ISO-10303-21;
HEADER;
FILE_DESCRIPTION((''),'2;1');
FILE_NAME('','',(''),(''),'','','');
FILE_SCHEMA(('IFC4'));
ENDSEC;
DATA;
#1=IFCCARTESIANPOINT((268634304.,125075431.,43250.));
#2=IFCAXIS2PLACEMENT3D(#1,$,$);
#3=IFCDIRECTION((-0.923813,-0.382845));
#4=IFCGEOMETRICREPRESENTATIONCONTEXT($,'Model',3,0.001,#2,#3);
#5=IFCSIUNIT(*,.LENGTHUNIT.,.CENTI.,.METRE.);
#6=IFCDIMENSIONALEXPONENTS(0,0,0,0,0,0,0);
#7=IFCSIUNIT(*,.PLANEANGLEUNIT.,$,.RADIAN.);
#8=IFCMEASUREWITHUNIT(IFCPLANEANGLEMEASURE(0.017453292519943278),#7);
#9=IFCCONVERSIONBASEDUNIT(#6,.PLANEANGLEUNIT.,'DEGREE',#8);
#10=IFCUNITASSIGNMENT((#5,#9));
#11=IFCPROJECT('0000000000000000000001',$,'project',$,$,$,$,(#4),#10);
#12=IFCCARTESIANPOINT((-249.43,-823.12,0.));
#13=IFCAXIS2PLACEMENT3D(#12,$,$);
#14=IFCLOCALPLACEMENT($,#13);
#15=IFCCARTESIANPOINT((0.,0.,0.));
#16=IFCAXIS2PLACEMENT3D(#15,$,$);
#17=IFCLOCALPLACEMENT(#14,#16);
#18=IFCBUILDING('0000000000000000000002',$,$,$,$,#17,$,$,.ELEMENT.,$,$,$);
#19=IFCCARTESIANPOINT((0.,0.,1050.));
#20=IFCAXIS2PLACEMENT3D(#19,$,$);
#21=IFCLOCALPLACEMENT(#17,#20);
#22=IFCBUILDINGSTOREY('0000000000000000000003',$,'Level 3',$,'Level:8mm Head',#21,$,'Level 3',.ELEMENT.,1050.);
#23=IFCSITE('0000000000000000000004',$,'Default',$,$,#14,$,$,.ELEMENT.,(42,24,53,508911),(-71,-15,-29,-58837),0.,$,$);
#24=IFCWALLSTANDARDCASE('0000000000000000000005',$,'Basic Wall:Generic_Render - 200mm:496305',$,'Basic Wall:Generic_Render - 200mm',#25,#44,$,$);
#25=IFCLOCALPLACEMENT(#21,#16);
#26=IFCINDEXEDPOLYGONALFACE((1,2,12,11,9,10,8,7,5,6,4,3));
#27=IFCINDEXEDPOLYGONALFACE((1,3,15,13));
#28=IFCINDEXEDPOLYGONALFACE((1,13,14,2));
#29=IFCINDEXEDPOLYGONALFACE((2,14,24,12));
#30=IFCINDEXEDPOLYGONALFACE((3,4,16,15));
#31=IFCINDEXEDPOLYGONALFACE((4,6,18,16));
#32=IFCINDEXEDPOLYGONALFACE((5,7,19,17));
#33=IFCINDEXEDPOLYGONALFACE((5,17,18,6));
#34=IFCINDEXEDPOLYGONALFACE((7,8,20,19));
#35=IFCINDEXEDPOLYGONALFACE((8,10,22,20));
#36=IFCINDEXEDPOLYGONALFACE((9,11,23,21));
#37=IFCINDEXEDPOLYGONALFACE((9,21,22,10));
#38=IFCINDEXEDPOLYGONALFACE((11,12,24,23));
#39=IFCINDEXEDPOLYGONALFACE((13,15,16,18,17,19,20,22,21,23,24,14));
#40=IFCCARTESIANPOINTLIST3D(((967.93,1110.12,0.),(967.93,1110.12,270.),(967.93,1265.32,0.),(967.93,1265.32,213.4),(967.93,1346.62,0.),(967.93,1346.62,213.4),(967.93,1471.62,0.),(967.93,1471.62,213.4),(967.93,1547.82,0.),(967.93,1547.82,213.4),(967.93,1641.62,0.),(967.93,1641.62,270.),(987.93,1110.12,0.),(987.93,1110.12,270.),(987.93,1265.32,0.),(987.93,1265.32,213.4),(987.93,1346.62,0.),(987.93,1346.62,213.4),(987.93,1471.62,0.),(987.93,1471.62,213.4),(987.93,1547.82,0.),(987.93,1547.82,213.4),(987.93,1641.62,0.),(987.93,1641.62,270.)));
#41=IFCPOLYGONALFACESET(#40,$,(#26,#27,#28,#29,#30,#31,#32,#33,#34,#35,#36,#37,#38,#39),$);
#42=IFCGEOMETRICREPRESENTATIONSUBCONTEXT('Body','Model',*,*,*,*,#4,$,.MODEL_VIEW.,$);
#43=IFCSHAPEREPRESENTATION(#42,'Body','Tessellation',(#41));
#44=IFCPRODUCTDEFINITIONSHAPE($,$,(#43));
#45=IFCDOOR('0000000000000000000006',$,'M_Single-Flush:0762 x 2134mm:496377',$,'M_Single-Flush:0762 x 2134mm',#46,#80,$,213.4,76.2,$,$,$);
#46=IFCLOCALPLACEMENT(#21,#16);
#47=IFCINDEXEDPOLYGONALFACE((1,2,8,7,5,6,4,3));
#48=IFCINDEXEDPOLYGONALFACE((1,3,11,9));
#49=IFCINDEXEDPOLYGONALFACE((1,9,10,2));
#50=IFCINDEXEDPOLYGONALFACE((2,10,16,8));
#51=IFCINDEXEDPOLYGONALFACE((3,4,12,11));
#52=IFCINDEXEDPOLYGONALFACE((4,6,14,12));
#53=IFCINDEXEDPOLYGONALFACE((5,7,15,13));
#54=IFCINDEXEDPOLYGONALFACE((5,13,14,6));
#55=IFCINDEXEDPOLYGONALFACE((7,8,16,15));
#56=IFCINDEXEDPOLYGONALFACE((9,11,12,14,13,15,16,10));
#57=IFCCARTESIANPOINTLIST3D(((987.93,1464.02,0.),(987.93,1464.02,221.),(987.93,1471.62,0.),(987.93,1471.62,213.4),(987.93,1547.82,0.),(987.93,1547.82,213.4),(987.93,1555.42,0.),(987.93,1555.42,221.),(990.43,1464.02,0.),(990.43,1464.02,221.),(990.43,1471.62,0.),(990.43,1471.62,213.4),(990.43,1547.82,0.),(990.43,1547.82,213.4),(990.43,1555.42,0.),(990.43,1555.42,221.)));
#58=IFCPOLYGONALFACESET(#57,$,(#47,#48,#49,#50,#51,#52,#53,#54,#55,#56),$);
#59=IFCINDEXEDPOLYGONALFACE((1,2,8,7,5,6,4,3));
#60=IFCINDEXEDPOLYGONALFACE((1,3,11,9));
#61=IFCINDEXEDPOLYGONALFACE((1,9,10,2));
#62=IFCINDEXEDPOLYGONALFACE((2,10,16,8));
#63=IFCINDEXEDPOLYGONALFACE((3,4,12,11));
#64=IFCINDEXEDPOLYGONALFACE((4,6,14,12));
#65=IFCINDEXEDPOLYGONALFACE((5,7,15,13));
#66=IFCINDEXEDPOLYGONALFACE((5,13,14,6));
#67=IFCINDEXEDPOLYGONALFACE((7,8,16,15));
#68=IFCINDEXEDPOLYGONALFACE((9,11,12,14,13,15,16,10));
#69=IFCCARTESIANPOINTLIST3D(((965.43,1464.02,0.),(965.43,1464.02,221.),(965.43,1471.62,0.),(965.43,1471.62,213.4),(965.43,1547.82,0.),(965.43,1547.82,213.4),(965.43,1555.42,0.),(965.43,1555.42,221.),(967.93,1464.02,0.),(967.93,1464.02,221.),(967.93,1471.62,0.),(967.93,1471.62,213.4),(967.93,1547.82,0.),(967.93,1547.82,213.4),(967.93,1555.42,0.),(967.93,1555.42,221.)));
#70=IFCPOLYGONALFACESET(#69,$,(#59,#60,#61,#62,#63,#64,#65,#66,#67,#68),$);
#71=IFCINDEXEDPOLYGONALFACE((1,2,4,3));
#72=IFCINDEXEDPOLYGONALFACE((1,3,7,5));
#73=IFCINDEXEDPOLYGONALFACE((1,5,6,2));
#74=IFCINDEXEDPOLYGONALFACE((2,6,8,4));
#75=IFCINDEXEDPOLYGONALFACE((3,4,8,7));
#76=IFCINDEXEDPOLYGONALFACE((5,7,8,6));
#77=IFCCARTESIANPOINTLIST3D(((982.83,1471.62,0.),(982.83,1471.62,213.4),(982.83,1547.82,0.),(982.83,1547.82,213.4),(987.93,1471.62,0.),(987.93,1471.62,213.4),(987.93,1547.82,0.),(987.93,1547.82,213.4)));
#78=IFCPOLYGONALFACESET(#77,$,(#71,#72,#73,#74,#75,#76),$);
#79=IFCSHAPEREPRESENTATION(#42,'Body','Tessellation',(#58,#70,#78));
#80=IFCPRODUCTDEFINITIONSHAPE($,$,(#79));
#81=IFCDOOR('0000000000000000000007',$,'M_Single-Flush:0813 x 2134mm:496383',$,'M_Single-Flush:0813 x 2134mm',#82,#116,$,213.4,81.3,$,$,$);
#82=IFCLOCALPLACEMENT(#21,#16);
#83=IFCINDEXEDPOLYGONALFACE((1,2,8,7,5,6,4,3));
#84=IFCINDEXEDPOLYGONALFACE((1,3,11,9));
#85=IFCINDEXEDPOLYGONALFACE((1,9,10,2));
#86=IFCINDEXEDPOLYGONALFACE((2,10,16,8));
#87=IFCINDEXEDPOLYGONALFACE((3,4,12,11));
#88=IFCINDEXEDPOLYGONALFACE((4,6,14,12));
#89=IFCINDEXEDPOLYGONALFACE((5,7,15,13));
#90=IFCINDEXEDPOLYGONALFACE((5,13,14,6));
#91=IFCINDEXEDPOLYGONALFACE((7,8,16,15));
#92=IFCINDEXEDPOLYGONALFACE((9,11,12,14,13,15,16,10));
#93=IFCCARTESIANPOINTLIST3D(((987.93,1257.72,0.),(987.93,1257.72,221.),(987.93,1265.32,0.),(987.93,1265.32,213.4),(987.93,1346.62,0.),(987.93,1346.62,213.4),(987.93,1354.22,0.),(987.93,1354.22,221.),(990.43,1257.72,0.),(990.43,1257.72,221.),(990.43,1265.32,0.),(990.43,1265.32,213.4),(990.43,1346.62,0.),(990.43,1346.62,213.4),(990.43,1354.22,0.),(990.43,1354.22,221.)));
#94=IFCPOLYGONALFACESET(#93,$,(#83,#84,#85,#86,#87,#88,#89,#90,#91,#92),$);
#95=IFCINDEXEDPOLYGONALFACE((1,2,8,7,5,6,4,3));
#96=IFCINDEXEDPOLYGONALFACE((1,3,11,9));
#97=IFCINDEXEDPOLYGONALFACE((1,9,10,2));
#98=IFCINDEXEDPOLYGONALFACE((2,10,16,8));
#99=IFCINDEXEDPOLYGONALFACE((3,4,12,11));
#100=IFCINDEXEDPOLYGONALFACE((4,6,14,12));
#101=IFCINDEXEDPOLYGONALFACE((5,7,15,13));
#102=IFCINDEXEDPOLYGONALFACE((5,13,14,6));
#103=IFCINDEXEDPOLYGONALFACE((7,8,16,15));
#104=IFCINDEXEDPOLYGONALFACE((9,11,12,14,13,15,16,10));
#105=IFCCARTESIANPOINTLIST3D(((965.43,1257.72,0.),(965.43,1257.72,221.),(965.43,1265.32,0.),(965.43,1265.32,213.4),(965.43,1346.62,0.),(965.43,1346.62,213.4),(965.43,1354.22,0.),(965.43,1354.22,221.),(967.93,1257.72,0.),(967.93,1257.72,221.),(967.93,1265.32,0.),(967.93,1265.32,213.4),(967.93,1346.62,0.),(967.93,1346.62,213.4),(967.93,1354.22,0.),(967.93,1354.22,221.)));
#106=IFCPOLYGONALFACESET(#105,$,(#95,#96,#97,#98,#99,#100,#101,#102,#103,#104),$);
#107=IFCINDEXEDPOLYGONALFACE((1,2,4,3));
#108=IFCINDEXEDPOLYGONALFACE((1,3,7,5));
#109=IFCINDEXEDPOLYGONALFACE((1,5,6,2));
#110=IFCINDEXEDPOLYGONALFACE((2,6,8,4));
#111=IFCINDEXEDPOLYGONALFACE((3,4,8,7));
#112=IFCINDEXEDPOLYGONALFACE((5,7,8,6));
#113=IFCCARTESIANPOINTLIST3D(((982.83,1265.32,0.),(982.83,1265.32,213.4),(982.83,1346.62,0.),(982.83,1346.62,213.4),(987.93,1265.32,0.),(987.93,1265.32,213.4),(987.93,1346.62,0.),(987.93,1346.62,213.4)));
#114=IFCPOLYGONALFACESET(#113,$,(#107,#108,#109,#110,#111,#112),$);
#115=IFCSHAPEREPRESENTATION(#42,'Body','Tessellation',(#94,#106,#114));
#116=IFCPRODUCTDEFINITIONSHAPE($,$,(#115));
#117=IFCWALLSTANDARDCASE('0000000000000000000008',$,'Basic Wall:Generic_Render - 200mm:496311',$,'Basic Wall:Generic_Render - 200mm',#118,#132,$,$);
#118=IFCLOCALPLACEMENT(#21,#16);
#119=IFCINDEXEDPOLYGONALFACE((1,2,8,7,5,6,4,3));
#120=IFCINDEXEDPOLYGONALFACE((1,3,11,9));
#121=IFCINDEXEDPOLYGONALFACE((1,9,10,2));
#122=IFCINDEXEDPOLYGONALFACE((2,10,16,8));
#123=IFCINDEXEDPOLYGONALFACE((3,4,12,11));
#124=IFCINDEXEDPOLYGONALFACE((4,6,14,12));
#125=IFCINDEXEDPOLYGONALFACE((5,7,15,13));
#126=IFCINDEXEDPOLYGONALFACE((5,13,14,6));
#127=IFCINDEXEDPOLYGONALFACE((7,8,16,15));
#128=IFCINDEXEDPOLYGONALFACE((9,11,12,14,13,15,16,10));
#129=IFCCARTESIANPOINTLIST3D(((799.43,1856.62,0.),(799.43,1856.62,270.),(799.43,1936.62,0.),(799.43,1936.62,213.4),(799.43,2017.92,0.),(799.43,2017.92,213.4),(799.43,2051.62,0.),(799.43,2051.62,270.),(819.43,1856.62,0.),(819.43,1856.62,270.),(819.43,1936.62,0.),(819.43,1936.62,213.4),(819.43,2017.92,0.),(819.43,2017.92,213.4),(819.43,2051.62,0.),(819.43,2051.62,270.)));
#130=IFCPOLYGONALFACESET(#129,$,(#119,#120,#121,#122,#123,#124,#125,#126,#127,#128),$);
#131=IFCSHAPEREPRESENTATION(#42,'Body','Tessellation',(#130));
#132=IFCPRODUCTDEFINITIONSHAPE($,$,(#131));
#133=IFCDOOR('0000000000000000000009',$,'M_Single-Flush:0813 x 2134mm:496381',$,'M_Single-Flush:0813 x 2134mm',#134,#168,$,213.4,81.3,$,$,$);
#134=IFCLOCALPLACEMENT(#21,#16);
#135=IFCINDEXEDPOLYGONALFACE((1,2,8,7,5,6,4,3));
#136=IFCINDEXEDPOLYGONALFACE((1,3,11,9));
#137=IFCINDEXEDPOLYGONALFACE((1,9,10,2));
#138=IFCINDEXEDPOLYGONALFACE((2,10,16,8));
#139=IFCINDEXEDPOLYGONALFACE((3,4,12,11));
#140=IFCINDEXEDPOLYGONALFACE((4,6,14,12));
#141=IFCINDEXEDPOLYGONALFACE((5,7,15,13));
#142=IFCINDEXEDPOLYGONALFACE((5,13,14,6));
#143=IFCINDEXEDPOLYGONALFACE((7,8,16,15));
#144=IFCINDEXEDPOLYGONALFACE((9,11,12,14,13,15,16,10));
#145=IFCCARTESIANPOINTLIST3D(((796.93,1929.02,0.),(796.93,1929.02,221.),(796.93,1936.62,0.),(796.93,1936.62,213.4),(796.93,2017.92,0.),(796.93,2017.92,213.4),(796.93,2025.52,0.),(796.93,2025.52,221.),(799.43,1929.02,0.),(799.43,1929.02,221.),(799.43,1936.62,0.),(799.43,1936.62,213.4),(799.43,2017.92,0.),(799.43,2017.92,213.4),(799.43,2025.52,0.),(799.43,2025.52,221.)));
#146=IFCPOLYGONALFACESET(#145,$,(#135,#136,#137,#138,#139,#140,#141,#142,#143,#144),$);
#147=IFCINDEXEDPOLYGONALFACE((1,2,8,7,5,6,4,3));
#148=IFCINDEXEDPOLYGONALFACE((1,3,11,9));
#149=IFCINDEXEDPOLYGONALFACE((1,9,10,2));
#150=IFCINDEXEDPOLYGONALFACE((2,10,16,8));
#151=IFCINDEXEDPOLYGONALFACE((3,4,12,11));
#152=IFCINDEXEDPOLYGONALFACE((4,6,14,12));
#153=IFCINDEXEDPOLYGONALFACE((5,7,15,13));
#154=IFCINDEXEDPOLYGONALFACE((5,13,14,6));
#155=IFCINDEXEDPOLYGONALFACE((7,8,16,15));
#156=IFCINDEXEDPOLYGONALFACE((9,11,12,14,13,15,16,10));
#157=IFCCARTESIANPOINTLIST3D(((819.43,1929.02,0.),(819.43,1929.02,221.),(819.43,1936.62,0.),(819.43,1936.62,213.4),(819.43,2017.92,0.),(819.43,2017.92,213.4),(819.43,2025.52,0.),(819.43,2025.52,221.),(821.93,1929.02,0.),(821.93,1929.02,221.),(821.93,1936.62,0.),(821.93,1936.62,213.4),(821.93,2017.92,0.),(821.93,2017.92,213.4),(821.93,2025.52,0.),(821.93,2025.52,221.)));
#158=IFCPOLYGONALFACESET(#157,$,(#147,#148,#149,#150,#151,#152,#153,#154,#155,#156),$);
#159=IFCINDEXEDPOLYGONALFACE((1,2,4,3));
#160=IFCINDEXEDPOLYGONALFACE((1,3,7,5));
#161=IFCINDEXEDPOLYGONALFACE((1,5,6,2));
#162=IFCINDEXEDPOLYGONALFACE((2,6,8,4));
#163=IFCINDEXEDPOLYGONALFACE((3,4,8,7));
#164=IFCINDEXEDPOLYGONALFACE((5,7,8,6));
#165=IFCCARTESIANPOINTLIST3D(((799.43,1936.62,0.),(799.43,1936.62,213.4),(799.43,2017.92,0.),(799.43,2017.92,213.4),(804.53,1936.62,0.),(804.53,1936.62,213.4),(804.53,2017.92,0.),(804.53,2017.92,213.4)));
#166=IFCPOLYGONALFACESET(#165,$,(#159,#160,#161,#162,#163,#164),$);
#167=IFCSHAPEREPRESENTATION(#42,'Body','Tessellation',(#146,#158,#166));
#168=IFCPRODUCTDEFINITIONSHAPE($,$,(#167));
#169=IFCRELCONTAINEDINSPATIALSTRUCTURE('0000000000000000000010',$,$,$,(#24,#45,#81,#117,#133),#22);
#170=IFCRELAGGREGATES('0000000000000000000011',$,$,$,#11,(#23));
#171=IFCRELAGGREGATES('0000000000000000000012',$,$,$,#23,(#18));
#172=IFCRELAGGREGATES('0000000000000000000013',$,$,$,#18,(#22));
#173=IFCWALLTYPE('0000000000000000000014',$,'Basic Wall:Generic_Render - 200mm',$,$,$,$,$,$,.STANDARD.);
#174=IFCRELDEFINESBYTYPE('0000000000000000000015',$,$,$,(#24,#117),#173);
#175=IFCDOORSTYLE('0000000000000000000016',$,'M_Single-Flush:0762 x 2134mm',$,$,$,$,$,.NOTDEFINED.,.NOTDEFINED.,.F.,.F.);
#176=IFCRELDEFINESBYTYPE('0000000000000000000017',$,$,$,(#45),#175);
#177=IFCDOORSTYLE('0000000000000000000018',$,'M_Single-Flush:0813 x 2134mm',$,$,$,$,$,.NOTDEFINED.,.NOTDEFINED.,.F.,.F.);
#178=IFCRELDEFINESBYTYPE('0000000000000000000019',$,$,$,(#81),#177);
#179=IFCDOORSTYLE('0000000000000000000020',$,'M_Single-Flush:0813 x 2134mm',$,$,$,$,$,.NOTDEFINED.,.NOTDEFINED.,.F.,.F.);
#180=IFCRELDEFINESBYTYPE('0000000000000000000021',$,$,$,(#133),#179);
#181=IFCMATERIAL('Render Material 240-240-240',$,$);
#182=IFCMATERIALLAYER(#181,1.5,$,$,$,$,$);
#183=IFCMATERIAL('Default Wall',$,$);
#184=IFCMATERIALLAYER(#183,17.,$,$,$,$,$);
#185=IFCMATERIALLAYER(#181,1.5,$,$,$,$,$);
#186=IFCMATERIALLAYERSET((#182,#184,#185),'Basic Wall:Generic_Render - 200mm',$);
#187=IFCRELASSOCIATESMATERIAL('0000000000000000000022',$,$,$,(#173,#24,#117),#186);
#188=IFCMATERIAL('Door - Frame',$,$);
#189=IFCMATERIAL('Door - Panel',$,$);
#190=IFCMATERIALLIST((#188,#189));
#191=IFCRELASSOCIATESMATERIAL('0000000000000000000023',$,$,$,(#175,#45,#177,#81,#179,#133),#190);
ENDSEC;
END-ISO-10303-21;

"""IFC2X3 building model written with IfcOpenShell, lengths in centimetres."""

from ifc_helpers import new_model, entity, si_unit, converted_unit, direction, frame, frame_2d, origin, place, context, subcontext, project, spatial, polyline, rectangle, outline, extrude, source, transform, mapped, material, material_list, layer, layer_set, layer_usage, type_object, type_shapes, element, fill, save


model = new_model("IFC2X3")

# Units and contexts
model_context = context("Model", 3, precision=0.001, world=frame((268634304.0, 125075431.0, 43250.0)), true_north=direction((-0.923813, -0.382845)))
body_context = subcontext(model_context, "Body", "Model", "MODEL_VIEW")
ifc_project = project(units=[si_unit("LENGTHUNIT", "METRE", prefix="CENTI"), converted_unit("PLANEANGLEUNIT", "DEGREE", entity("IfcPlaneAngleMeasure", 0.017453292519943278), si_unit("PLANEANGLEUNIT", "RADIAN"), dimensions=[0, 0, 0, 0, 0, 0, 0])], contexts=[model_context])

# Site, building, storey
site_placement = place(None, frame((-249.43, -823.12, 0.0)))
site = spatial("IfcSite", under=ifc_project, at=site_placement, Name="Default", CompositionType="ELEMENT", RefLatitude=(42, 24, 53, 508911), RefLongitude=(-71, -15, -29, -58837), RefElevation=0.0)
building_placement = place(site_placement, origin())
building = spatial("IfcBuilding", under=site, at=building_placement, CompositionType="ELEMENT")
storey_placement = place(building_placement, frame((0.0, 0.0, 1050.0)))
storey = spatial("IfcBuildingStorey", under=building, at=storey_placement, Name="Level 3", ObjectType="Level:8mm Head", LongName="Level 3", CompositionType="ELEMENT", Elevation=1050.0)

# Shared definitions
ifc_material_1 = material(Name="Render Material 240-240-240")

# Shared definitions
ifc_layer_1 = layer(ifc_material_1, 1.5)
ifc_material_2 = material(Name="Default Wall")
ifc_layer_2 = layer(ifc_material_2, 17.0)
ifc_layer_3 = layer(ifc_material_1, 1.5)
ifc_layer_set_1 = layer_set([ifc_layer_1, ifc_layer_2, ifc_layer_3], Name="Basic Wall:Generic_Render - 200mm")
wall_type_1 = type_object("IfcWallType", Name="Basic Wall:Generic_Render - 200mm", PredefinedType="STANDARD", material=ifc_layer_set_1)
ifc_material_3 = material(Name="Door - Frame")
ifc_material_4 = material(Name="Door - Panel")
ifc_material_list = material_list([ifc_material_3, ifc_material_4])

# Wall, openings, doors
ifc_layer_usage_1 = layer_usage(ifc_layer_set_1, "AXIS2", "NEGATIVE", 10.0)
wall_1_placement = place(storey_placement, frame((977.93, 1641.62, 0.0), z_axis=(0.0, 0.0, 1.0), x_axis=(0.0, -1.0, 0.0)))
wall_1 = element("IfcWallStandardCase", 1, at=wall_1_placement, inside=storey, type_object=wall_type_1, material=ifc_layer_usage_1, Name="Basic Wall:Generic_Render - 200mm:496305", ObjectType="Basic Wall:Generic_Render - 200mm", context=body_context, shape_type="SweptSolid", body=[
    extrude(rectangle(XDim=531.5, YDim=20.0, at=frame_2d((265.75, 0.0), x_axis=(1.0, 0.0))), origin(), (0.0, 0.0, 1.0), 270.0),
])
opening_1_placement = place(wall_1_placement, frame((93.8, -10.0, 0.0)))
opening_1 = element("IfcOpeningElement", 2, at=opening_1_placement, cuts=wall_1, ObjectType="Opening", context=body_context, shape_type="SweptSolid", body=[
    extrude(rectangle(XDim=76.2, YDim=213.4, at=frame_2d((106.7, 38.1), x_axis=(0.0, 1.0))), frame((0.0, 0.0, 0.0), z_axis=(0.0, 1.0, 0.0), x_axis=(0.0, 0.0, 1.0)), (0.0, 0.0, 1.0), 20.0),
])
opening_2_placement = place(wall_1_placement, frame((295.0, -10.0, 0.0)))
opening_2 = element("IfcOpeningElement", 3, at=opening_2_placement, cuts=wall_1, ObjectType="Opening", context=body_context, shape_type="SweptSolid", body=[
    extrude(rectangle(XDim=81.3, YDim=213.4, at=frame_2d((106.7, 40.65), x_axis=(0.0, -1.0))), frame((0.0, 0.0, 0.0), z_axis=(0.0, 1.0, 0.0), x_axis=(0.0, 0.0, 1.0)), (0.0, 0.0, 1.0), 20.0),
])
door_style_1 = type_object("IfcDoorStyle", Name="M_Single-Flush:0762 x 2134mm", ConstructionType="NOTDEFINED", OperationType="NOTDEFINED", ParameterTakesPrecedence=False, Sizeable=False, material=ifc_material_list)
shared_shape_1 = source(origin(), body_context, "Body", "SweptSolid", [
    extrude(outline(polyline([(-45.7, -112.4), (45.7, -112.4), (45.7, 108.6), (38.1, 108.6), (38.1, -104.8), (-38.1, -104.8), (-38.1, 108.6), (-45.7, 108.6), (-45.7, -112.4)])), frame((38.1, 20.0, 108.6), z_axis=(0.0, 1.0, 0.0), x_axis=(1.0, 0.0, 0.0)), (0.0, 0.0, 1.0), 2.5),
    extrude(outline(polyline([(-112.4, -45.7), (108.6, -45.7), (108.6, -38.1), (-104.8, -38.1), (-104.8, 38.1), (108.6, 38.1), (108.6, 45.7), (-112.4, 45.7), (-112.4, -45.7)])), frame((38.1, -2.5, 108.6), z_axis=(0.0, 1.0, 0.0), x_axis=(0.0, 0.0, -1.0)), (0.0, 0.0, 1.0), 2.5),
    extrude(rectangle(XDim=5.1, YDim=76.2, at=frame_2d((0.0, 0.0), x_axis=(1.0, 0.0))), frame((38.1, 17.45, 0.0), z_axis=(0.0, 0.0, 1.0), x_axis=(0.0, 1.0, 0.0)), (0.0, 0.0, 1.0), 213.4),
])
type_shapes(door_style_1, [shared_shape_1])
door_1_placement = place(opening_1_placement, origin())
door_1 = element("IfcDoor", 4, at=door_1_placement, inside=storey, type_object=door_style_1, material=ifc_material_list, Name="M_Single-Flush:0762 x 2134mm:496377", ObjectType="M_Single-Flush:0762 x 2134mm", OverallHeight=213.4, OverallWidth=76.2, context=body_context, shape_type="MappedRepresentation", body=[
    mapped(shared_shape_1, transform((0.0, 0.0, 0.0), scale=1.0)),
])
fill(opening_1, door_1)
door_style_2 = type_object("IfcDoorStyle", Name="M_Single-Flush:0813 x 2134mm", ConstructionType="NOTDEFINED", OperationType="NOTDEFINED", ParameterTakesPrecedence=False, Sizeable=False, material=ifc_material_list)
shared_shape_2 = source(origin(), body_context, "Body", "SweptSolid", [
    extrude(outline(polyline([(-48.25, -112.4), (48.25, -112.4), (48.25, 108.6), (40.65, 108.6), (40.65, -104.8), (-40.65, -104.8), (-40.65, 108.6), (-48.25, 108.6), (-48.25, -112.4)])), frame((40.65, 22.5, 108.6), z_axis=(0.0, -1.0, 0.0), x_axis=(-1.0, 0.0, 0.0)), (0.0, 0.0, 1.0), 2.5),
    extrude(outline(polyline([(-112.4, -48.25), (108.6, -48.25), (108.6, -40.65), (-104.8, -40.65), (-104.8, 40.65), (108.6, 40.65), (108.6, 48.25), (-112.4, 48.25), (-112.4, -48.25)])), frame((40.65, 0.0, 108.6), z_axis=(0.0, -1.0, 0.0), x_axis=(0.0, 0.0, -1.0)), (0.0, 0.0, 1.0), 2.5),
    extrude(rectangle(XDim=81.3, YDim=5.1, at=frame_2d((0.0, 0.0), x_axis=(1.0, 0.0))), frame((40.65, 17.45, 0.0)), (0.0, 0.0, 1.0), 213.4),
])
type_shapes(door_style_2, [shared_shape_2])
door_2_placement = place(opening_2_placement, origin())
door_2 = element("IfcDoor", 5, at=door_2_placement, inside=storey, type_object=door_style_2, material=ifc_material_list, Name="M_Single-Flush:0813 x 2134mm:496383", ObjectType="M_Single-Flush:0813 x 2134mm", OverallHeight=213.4, OverallWidth=81.3, context=body_context, shape_type="MappedRepresentation", body=[
    mapped(shared_shape_2, transform((0.0, 0.0, 0.0), scale=1.0)),
])
fill(opening_2, door_2)

# Wall, opening, door
ifc_layer_usage_2 = layer_usage(ifc_layer_set_1, "AXIS2", "NEGATIVE", 10.0)
wall_2_placement = place(storey_placement, frame((809.43, 1856.62, 0.0), z_axis=(0.0, 0.0, 1.0), x_axis=(0.0, 1.0, 0.0)))
wall_2 = element("IfcWallStandardCase", 6, at=wall_2_placement, inside=storey, type_object=wall_type_1, material=ifc_layer_usage_2, Name="Basic Wall:Generic_Render - 200mm:496311", ObjectType="Basic Wall:Generic_Render - 200mm", context=body_context, shape_type="SweptSolid", body=[
    extrude(rectangle(XDim=195.0, YDim=20.0, at=frame_2d((97.5, 0.0), x_axis=(-1.0, 0.0))), origin(), (0.0, 0.0, 1.0), 270.0),
])
opening_3_placement = place(wall_2_placement, frame((80.0, -10.0, 0.0)))
opening_3 = element("IfcOpeningElement", 7, at=opening_3_placement, cuts=wall_2, ObjectType="Opening", context=body_context, shape_type="SweptSolid", body=[
    extrude(rectangle(XDim=81.3, YDim=213.4, at=frame_2d((106.7, 40.65), x_axis=(0.0, 1.0))), frame((0.0, 0.0, 0.0), z_axis=(0.0, 1.0, 0.0), x_axis=(0.0, 0.0, 1.0)), (0.0, 0.0, 1.0), 20.0),
])
door_style_3 = type_object("IfcDoorStyle", Name="M_Single-Flush:0813 x 2134mm", ConstructionType="NOTDEFINED", OperationType="NOTDEFINED", ParameterTakesPrecedence=False, Sizeable=False, material=ifc_material_list)
shared_shape_3 = source(origin(), body_context, "Body", "SweptSolid", [
    extrude(outline(polyline([(-48.25, -112.4), (48.25, -112.4), (48.25, 108.6), (40.65, 108.6), (40.65, -104.8), (-40.65, -104.8), (-40.65, 108.6), (-48.25, 108.6), (-48.25, -112.4)])), frame((40.65, 20.0, 108.6), z_axis=(0.0, 1.0, 0.0), x_axis=(1.0, 0.0, 0.0)), (0.0, 0.0, 1.0), 2.5),
    extrude(outline(polyline([(-112.4, -48.25), (108.6, -48.25), (108.6, -40.65), (-104.8, -40.65), (-104.8, 40.65), (108.6, 40.65), (108.6, 48.25), (-112.4, 48.25), (-112.4, -48.25)])), frame((40.65, -2.5, 108.6), z_axis=(0.0, 1.0, 0.0), x_axis=(0.0, 0.0, -1.0)), (0.0, 0.0, 1.0), 2.5),
    extrude(rectangle(XDim=5.1, YDim=81.3, at=frame_2d((0.0, 0.0), x_axis=(1.0, 0.0))), frame((40.65, 17.45, 0.0), z_axis=(0.0, 0.0, 1.0), x_axis=(0.0, 1.0, 0.0)), (0.0, 0.0, 1.0), 213.4),
])
type_shapes(door_style_3, [shared_shape_3])
door_3_placement = place(opening_3_placement, origin())
door_3 = element("IfcDoor", 8, at=door_3_placement, inside=storey, type_object=door_style_3, material=ifc_material_list, Name="M_Single-Flush:0813 x 2134mm:496381", ObjectType="M_Single-Flush:0813 x 2134mm", OverallHeight=213.4, OverallWidth=81.3, context=body_context, shape_type="MappedRepresentation", body=[
    mapped(shared_shape_3, transform((0.0, 0.0, 0.0), scale=1.0)),
])
fill(opening_3, door_3)

save(model, "model.ifc")
